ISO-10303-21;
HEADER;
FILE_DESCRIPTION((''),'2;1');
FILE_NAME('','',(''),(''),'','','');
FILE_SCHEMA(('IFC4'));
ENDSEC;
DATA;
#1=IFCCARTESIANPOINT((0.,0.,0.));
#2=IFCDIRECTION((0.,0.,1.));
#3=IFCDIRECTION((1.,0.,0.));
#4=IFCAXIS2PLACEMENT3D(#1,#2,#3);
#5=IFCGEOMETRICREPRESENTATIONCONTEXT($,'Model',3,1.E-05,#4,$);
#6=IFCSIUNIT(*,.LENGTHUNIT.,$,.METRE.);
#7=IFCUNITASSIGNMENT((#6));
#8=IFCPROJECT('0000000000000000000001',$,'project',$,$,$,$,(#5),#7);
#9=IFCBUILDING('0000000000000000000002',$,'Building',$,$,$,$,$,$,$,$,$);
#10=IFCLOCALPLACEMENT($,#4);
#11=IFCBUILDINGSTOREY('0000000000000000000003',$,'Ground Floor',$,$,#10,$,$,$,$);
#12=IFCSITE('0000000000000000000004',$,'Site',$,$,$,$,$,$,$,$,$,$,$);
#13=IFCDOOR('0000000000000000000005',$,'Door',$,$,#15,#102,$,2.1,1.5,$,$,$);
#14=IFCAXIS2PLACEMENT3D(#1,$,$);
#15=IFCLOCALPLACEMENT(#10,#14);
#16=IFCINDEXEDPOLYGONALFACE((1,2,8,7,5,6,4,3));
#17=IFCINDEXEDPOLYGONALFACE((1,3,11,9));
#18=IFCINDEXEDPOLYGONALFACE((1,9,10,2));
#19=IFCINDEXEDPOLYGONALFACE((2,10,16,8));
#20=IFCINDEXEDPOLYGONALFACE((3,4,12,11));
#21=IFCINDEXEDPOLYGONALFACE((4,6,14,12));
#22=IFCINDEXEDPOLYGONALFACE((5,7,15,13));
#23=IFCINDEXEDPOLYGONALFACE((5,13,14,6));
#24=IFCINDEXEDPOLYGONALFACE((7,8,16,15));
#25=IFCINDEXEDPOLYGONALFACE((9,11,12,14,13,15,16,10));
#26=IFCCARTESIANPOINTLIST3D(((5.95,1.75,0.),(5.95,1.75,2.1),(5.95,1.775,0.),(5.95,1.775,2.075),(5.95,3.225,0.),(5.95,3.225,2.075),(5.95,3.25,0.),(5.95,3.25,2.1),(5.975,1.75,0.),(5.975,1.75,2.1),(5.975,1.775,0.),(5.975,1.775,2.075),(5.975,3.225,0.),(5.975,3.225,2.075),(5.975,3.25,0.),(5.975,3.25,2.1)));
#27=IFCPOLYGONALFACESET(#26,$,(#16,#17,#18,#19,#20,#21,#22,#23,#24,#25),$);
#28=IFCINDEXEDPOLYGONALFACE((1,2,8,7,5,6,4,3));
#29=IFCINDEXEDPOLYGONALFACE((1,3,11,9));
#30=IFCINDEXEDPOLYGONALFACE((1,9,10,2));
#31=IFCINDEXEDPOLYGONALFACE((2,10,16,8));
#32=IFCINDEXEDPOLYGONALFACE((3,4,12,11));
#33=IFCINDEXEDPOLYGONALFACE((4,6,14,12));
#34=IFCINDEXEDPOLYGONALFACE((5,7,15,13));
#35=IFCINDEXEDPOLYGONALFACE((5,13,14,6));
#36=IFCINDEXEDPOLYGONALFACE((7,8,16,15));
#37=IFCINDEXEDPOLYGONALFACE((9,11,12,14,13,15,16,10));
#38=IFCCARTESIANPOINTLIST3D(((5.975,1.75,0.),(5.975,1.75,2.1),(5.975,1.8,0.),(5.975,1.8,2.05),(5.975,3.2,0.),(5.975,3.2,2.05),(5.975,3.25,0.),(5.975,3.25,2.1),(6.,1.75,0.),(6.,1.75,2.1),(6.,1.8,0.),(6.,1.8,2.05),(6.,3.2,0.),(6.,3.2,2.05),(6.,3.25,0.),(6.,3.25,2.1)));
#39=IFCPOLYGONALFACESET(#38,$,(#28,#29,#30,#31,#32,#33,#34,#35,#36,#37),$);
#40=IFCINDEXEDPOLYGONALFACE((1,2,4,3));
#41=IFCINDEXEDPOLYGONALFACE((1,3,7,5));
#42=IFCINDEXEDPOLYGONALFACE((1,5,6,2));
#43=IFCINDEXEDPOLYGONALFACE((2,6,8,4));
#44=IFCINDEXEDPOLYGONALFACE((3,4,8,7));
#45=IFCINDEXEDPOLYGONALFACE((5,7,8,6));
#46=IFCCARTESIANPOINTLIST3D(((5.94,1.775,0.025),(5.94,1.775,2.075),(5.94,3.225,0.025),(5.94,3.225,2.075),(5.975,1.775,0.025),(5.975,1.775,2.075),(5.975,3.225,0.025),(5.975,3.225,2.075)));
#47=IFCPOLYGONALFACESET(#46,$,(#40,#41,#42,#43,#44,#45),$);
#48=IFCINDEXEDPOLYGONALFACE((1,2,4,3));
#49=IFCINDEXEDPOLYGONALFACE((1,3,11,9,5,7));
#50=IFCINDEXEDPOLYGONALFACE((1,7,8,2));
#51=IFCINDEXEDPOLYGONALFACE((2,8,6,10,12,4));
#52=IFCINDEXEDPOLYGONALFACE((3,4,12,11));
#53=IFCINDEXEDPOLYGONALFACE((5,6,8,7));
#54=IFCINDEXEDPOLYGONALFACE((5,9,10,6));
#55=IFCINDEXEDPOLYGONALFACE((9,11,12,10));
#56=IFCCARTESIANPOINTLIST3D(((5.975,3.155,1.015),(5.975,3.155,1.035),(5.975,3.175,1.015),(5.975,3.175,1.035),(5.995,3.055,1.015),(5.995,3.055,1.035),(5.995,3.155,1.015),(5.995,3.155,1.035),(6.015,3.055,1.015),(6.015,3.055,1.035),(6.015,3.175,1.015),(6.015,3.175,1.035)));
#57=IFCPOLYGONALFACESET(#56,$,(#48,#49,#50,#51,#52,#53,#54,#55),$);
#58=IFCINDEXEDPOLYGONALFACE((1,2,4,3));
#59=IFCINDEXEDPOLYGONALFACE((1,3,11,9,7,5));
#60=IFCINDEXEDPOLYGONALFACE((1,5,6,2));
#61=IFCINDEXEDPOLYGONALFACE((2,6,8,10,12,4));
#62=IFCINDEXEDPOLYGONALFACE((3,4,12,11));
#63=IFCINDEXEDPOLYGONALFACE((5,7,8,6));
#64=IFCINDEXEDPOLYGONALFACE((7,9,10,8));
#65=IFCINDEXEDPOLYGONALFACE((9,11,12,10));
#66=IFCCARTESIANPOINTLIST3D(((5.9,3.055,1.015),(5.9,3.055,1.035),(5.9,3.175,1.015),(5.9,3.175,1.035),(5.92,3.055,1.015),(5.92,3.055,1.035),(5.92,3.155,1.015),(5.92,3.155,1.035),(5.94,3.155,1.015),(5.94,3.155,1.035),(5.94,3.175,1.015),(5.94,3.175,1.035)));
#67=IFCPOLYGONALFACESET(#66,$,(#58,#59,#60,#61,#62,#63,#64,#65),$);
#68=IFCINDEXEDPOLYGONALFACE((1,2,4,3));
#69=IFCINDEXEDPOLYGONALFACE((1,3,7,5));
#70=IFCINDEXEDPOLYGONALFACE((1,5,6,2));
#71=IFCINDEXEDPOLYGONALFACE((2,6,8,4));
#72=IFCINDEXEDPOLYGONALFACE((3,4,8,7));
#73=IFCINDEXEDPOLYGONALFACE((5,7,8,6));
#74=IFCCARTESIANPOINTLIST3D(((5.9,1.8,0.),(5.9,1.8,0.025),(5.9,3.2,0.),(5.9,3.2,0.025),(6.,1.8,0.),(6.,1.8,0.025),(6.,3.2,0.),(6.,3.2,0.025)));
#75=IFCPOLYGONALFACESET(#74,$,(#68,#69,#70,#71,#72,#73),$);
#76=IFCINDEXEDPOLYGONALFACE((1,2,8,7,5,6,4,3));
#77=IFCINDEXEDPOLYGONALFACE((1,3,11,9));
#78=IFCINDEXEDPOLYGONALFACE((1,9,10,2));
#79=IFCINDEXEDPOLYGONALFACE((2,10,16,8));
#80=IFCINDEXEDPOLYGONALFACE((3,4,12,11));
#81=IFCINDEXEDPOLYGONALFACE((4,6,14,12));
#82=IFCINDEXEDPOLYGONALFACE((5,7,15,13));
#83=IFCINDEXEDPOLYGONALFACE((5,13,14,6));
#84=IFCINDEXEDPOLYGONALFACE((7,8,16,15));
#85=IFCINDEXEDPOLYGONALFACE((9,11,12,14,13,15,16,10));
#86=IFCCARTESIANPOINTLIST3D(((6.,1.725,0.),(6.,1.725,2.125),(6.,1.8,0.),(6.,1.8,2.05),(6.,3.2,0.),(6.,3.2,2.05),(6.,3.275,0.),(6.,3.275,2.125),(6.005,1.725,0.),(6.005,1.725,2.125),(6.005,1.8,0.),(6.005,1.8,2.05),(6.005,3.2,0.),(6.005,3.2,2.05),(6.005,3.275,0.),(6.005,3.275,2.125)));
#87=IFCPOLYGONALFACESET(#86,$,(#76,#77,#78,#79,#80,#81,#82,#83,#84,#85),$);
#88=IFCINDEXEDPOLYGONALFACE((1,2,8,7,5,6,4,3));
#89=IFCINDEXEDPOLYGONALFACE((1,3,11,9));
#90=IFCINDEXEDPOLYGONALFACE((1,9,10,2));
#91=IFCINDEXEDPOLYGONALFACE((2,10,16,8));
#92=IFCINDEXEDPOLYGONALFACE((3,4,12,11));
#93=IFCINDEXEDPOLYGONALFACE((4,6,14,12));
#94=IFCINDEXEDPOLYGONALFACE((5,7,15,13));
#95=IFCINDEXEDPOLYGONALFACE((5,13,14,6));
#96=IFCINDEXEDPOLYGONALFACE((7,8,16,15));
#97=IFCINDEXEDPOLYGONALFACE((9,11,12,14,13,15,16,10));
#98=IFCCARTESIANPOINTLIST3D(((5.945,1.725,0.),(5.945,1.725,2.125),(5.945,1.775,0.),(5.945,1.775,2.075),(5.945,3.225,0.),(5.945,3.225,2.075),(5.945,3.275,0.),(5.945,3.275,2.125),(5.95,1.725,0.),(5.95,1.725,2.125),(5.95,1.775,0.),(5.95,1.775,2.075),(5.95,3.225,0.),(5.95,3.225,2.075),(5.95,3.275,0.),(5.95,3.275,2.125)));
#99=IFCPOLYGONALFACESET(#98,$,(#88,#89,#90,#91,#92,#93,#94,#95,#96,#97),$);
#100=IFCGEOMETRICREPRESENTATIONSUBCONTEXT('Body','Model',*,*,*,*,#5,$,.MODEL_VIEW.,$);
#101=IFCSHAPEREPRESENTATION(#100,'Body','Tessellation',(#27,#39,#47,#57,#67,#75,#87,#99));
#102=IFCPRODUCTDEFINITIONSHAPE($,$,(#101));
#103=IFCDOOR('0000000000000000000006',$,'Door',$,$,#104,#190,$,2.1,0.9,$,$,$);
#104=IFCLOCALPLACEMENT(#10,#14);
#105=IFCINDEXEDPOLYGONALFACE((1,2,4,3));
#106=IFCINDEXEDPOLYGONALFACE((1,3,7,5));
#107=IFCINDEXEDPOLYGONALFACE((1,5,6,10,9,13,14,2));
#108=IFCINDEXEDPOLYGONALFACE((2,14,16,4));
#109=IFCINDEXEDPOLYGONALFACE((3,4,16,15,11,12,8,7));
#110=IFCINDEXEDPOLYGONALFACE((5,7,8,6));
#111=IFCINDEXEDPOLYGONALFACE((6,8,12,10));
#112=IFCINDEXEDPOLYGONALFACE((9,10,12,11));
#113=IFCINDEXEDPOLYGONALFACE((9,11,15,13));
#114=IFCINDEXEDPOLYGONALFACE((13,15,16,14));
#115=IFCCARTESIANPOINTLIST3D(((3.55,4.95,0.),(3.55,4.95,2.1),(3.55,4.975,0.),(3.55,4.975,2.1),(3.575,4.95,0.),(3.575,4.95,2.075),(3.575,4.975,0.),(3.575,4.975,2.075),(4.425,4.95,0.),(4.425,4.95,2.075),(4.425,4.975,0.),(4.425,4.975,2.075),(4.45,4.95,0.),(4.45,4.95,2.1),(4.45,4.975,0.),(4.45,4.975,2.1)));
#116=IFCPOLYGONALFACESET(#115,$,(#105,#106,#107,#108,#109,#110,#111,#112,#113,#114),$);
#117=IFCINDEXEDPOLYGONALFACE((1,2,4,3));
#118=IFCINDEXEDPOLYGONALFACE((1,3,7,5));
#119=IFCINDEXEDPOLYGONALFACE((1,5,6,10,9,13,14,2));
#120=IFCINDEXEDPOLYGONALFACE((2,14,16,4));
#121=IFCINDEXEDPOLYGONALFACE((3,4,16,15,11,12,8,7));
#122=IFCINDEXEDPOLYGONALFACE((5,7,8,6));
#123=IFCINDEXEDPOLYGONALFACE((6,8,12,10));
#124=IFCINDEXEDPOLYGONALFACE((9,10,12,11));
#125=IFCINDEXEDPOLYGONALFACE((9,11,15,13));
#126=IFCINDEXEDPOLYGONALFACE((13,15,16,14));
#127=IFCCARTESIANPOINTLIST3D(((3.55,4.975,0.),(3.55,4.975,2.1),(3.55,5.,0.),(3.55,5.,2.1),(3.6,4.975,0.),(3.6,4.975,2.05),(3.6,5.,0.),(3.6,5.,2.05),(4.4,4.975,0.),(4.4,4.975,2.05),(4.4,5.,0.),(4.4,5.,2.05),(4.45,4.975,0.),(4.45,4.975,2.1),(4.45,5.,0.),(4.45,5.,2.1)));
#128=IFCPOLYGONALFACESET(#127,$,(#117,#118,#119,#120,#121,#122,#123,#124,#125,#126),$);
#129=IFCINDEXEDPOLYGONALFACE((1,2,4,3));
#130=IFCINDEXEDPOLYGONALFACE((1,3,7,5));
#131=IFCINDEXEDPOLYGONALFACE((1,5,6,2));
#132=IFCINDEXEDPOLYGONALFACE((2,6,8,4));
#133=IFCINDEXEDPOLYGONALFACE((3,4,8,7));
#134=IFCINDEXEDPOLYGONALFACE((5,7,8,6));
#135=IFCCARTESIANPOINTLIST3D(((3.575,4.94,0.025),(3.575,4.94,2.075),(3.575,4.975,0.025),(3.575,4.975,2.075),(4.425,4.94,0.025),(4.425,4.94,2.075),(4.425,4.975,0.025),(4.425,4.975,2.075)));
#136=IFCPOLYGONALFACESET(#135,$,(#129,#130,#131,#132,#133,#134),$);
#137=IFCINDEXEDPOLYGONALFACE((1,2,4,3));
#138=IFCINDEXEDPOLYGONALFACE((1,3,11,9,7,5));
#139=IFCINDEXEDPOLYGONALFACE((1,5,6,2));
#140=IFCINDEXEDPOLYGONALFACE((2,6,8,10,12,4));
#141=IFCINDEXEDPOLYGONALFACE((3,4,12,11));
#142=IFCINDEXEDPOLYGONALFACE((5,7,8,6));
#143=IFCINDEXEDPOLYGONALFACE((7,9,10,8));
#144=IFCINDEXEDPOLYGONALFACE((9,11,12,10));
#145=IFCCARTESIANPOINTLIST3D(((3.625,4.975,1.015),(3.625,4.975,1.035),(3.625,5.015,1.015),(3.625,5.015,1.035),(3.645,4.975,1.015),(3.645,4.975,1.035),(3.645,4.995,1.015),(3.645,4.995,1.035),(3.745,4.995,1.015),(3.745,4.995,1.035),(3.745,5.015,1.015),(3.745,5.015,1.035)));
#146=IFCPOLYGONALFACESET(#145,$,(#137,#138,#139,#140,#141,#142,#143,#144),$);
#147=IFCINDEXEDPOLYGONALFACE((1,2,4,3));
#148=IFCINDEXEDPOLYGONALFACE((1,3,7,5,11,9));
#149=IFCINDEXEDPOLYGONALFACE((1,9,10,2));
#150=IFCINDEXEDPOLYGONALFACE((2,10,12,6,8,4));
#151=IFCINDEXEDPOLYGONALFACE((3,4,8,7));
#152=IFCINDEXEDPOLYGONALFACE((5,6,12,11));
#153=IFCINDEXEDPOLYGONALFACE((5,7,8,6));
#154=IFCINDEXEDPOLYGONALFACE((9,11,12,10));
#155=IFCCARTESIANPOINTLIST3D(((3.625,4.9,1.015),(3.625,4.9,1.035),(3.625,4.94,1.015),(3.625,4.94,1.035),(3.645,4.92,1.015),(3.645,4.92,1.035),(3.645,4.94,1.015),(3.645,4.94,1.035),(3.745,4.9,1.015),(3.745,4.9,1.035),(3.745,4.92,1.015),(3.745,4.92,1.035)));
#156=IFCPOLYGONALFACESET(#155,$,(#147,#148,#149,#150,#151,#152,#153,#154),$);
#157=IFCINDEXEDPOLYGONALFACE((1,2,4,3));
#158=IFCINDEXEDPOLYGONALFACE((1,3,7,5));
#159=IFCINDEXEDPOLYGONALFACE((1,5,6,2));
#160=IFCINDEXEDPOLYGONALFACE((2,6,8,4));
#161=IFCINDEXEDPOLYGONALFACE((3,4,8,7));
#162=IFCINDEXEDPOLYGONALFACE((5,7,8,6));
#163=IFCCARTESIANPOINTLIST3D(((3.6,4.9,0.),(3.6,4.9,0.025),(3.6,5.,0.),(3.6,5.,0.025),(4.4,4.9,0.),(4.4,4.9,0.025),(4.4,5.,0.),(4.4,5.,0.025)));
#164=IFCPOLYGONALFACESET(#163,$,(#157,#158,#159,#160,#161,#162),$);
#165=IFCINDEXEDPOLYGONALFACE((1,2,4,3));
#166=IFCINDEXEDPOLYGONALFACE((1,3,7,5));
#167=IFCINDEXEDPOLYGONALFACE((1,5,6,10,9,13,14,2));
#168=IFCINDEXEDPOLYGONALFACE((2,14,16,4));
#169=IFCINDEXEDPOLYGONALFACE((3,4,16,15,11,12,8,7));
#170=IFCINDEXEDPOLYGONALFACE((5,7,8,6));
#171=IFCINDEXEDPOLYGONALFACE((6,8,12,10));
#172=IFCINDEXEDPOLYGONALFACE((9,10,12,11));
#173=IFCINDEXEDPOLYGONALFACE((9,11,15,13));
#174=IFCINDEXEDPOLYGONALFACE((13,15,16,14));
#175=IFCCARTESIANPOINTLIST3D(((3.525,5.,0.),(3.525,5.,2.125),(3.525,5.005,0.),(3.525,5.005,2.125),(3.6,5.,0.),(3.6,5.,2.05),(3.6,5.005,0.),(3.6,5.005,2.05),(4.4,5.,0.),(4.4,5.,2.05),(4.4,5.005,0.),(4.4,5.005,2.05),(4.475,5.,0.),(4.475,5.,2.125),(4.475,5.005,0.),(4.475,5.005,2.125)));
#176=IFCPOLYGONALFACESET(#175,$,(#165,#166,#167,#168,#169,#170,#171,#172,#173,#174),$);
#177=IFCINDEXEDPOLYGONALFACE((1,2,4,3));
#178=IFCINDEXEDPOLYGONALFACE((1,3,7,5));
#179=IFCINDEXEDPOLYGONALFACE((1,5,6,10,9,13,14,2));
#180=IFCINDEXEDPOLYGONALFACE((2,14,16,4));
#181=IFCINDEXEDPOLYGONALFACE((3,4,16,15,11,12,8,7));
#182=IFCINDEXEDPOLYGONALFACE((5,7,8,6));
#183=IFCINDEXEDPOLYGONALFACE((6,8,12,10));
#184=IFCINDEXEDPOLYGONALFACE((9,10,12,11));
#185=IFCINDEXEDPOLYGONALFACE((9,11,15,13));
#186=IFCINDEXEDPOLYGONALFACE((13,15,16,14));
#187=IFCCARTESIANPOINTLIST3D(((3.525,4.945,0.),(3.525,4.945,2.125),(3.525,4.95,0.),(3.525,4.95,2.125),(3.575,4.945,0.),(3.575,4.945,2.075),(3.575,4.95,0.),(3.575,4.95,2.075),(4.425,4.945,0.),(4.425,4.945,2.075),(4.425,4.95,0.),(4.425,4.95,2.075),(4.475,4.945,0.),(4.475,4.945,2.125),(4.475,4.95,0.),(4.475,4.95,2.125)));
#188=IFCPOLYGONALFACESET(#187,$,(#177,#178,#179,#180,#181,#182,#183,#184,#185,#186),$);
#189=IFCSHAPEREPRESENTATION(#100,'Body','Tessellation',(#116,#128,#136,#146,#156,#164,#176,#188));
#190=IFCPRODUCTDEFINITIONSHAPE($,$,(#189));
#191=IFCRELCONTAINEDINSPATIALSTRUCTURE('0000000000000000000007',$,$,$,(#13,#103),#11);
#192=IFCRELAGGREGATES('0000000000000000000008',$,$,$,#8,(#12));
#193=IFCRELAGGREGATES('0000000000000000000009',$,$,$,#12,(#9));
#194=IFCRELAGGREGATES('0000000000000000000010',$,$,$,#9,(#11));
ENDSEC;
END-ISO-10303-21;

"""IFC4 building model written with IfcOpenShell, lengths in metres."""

from ifc_helpers import new_model, si_unit, frame, origin_with_axes, place, context, subcontext, project, spatial, line, indexed_curve, outline, extrude, element, save


model = new_model("IFC4")

# Units and contexts
model_context = context("Model", 3, precision=1e-05, world=origin_with_axes())
body_context = subcontext(model_context, "Body", "Model", "MODEL_VIEW")
ifc_project = project(units=[si_unit("LENGTHUNIT", "METRE")], contexts=[model_context])

# Site, building, storey
site = spatial("IfcSite", under=ifc_project, Name="Site")
building = spatial("IfcBuilding", under=site, Name="Building")
storey_placement = place(None, origin_with_axes())
storey = spatial("IfcBuildingStorey", under=building, at=storey_placement, Name="Ground Floor")

# Doors
door_1_placement = place(storey_placement, frame((6.0, 1.75, 0.0), z_axis=(0.0, 0.0, 1.0), x_axis=(0.0, 1.0, 0.0)))
element("IfcDoor", 1, at=door_1_placement, inside=storey, Name="Door", OverallHeight=2.1, OverallWidth=1.5, context=body_context, shape_type="SweptSolid", body=[
    extrude(outline(indexed_curve([(0.0, 0.0), (0.0, 2.1), (1.5, 2.1), (1.5, 0.0), (1.475, 0.0), (1.475, 2.075), (0.025, 2.075), (0.025, 0.0)], segments=[line(1, 2, 3, 4, 5, 6, 7, 8, 1)])), frame((0.0, 0.025, 0.0), z_axis=(0.0, -1.0, 0.0), x_axis=(1.0, 0.0, 0.0)), (0.0, 0.0, -1.0), 0.025),
    extrude(outline(indexed_curve([(0.0, 0.0), (0.0, 2.1), (1.5, 2.1), (1.5, 0.0), (1.45, 0.0), (1.45, 2.05), (0.05, 2.05), (0.05, 0.0)], segments=[line(1, 2, 3, 4, 5, 6, 7, 8, 1)])), frame((0.0, 0.0, 0.0), z_axis=(0.0, -1.0, 0.0), x_axis=(1.0, 0.0, 0.0)), (0.0, 0.0, -1.0), 0.025),
    extrude(outline(indexed_curve([(0.0, 0.0), (1.45, 0.0), (1.45, 0.035), (0.0, 0.035)], segments=[line(1, 2, 3, 4, 1)])), frame((0.025, 0.025, 0.025), z_axis=(0.0, 0.0, 1.0), x_axis=(1.0, 0.0, 0.0)), (0.0, 0.0, 1.0), 2.05),
    extrude(outline(indexed_curve([(0.0, 0.0), (0.0, -0.04), (-0.12, -0.04), (-0.12, -0.02), (-0.02, -0.02), (-0.02, 0.0)], segments=[line(1, 2, 3, 4, 5, 6, 1)])), frame((1.425, 0.025, 1.015), z_axis=(0.0, 0.0, 1.0), x_axis=(1.0, 0.0, 0.0)), (0.0, 0.0, 1.0), 0.02),
    extrude(outline(indexed_curve([(0.0, 0.0), (0.0, 0.04), (-0.12, 0.04), (-0.12, 0.02), (-0.02, 0.02), (-0.02, 0.0)], segments=[line(1, 2, 3, 4, 5, 6, 1)])), frame((1.425, 0.06, 1.015), z_axis=(0.0, 0.0, 1.0), x_axis=(1.0, 0.0, 0.0)), (0.0, 0.0, 1.0), 0.02),
    extrude(outline(indexed_curve([(0.0, 0.0), (1.4, 0.0), (1.4, 0.1), (0.0, 0.1)], segments=[line(1, 2, 3, 4, 1)])), frame((0.05, 0.0, 0.0), z_axis=(0.0, 0.0, 1.0), x_axis=(1.0, 0.0, 0.0)), (0.0, 0.0, 1.0), 0.025),
    extrude(outline(indexed_curve([(0.0, 0.0), (0.0, 2.125), (1.55, 2.125), (1.55, 0.0), (1.475, 0.0), (1.475, 2.05), (0.075, 2.05), (0.075, 0.0)], segments=[line(1, 2, 3, 4, 5, 6, 7, 8, 1)])), frame((-0.025, -0.005, 0.0), z_axis=(0.0, -1.0, 0.0), x_axis=(1.0, 0.0, 0.0)), (0.0, 0.0, -1.0), 0.005),
    extrude(outline(indexed_curve([(0.0, 0.0), (0.0, 2.125), (1.55, 2.125), (1.55, 0.0), (1.5, 0.0), (1.5, 2.075), (0.05, 2.075), (0.05, 0.0)], segments=[line(1, 2, 3, 4, 5, 6, 7, 8, 1)])), frame((-0.025, 0.05, 0.0), z_axis=(0.0, -1.0, 0.0), x_axis=(1.0, 0.0, 0.0)), (0.0, 0.0, -1.0), 0.005),
])
door_2_placement = place(storey_placement, frame((4.45, 5.0, 0.0), z_axis=(0.0, 0.0, 1.0), x_axis=(-1.0, 0.0, 0.0)))
element("IfcDoor", 2, at=door_2_placement, inside=storey, Name="Door", OverallHeight=2.1, OverallWidth=0.9, context=body_context, shape_type="SweptSolid", body=[
    extrude(outline(indexed_curve([(0.0, 0.0), (0.0, 2.1), (0.9, 2.1), (0.9, 0.0), (0.875, 0.0), (0.875, 2.075), (0.025, 2.075), (0.025, 0.0)], segments=[line(1, 2, 3, 4, 5, 6, 7, 8, 1)])), frame((0.0, 0.025, 0.0), z_axis=(0.0, -1.0, 0.0), x_axis=(1.0, 0.0, 0.0)), (0.0, 0.0, -1.0), 0.025),
    extrude(outline(indexed_curve([(0.0, 0.0), (0.0, 2.1), (0.9, 2.1), (0.9, 0.0), (0.85, 0.0), (0.85, 2.05), (0.05, 2.05), (0.05, 0.0)], segments=[line(1, 2, 3, 4, 5, 6, 7, 8, 1)])), frame((0.0, 0.0, 0.0), z_axis=(0.0, -1.0, 0.0), x_axis=(1.0, 0.0, 0.0)), (0.0, 0.0, -1.0), 0.025),
    extrude(outline(indexed_curve([(0.0, 0.0), (0.85, 0.0), (0.85, 0.035), (0.0, 0.035)], segments=[line(1, 2, 3, 4, 1)])), frame((0.025, 0.025, 0.025), z_axis=(0.0, 0.0, 1.0), x_axis=(1.0, 0.0, 0.0)), (0.0, 0.0, 1.0), 2.05),
    extrude(outline(indexed_curve([(0.0, 0.0), (0.0, -0.04), (-0.12, -0.04), (-0.12, -0.02), (-0.02, -0.02), (-0.02, 0.0)], segments=[line(1, 2, 3, 4, 5, 6, 1)])), frame((0.825, 0.025, 1.015), z_axis=(0.0, 0.0, 1.0), x_axis=(1.0, 0.0, 0.0)), (0.0, 0.0, 1.0), 0.02),
    extrude(outline(indexed_curve([(0.0, 0.0), (0.0, 0.04), (-0.12, 0.04), (-0.12, 0.02), (-0.02, 0.02), (-0.02, 0.0)], segments=[line(1, 2, 3, 4, 5, 6, 1)])), frame((0.825, 0.06, 1.015), z_axis=(0.0, 0.0, 1.0), x_axis=(1.0, 0.0, 0.0)), (0.0, 0.0, 1.0), 0.02),
    extrude(outline(indexed_curve([(0.0, 0.0), (0.8, 0.0), (0.8, 0.1), (0.0, 0.1)], segments=[line(1, 2, 3, 4, 1)])), frame((0.05, 0.0, 0.0), z_axis=(0.0, 0.0, 1.0), x_axis=(1.0, 0.0, 0.0)), (0.0, 0.0, 1.0), 0.025),
    extrude(outline(indexed_curve([(0.0, 0.0), (0.0, 2.125), (0.95, 2.125), (0.95, 0.0), (0.875, 0.0), (0.875, 2.05), (0.075, 2.05), (0.075, 0.0)], segments=[line(1, 2, 3, 4, 5, 6, 7, 8, 1)])), frame((-0.025, -0.005, 0.0), z_axis=(0.0, -1.0, 0.0), x_axis=(1.0, 0.0, 0.0)), (0.0, 0.0, -1.0), 0.005),
    extrude(outline(indexed_curve([(0.0, 0.0), (0.0, 2.125), (0.95, 2.125), (0.95, 0.0), (0.9, 0.0), (0.9, 2.075), (0.05, 2.075), (0.05, 0.0)], segments=[line(1, 2, 3, 4, 5, 6, 7, 8, 1)])), frame((-0.025, 0.05, 0.0), z_axis=(0.0, -1.0, 0.0), x_axis=(1.0, 0.0, 0.0)), (0.0, 0.0, -1.0), 0.005),
])

save(model, "model.ifc")
